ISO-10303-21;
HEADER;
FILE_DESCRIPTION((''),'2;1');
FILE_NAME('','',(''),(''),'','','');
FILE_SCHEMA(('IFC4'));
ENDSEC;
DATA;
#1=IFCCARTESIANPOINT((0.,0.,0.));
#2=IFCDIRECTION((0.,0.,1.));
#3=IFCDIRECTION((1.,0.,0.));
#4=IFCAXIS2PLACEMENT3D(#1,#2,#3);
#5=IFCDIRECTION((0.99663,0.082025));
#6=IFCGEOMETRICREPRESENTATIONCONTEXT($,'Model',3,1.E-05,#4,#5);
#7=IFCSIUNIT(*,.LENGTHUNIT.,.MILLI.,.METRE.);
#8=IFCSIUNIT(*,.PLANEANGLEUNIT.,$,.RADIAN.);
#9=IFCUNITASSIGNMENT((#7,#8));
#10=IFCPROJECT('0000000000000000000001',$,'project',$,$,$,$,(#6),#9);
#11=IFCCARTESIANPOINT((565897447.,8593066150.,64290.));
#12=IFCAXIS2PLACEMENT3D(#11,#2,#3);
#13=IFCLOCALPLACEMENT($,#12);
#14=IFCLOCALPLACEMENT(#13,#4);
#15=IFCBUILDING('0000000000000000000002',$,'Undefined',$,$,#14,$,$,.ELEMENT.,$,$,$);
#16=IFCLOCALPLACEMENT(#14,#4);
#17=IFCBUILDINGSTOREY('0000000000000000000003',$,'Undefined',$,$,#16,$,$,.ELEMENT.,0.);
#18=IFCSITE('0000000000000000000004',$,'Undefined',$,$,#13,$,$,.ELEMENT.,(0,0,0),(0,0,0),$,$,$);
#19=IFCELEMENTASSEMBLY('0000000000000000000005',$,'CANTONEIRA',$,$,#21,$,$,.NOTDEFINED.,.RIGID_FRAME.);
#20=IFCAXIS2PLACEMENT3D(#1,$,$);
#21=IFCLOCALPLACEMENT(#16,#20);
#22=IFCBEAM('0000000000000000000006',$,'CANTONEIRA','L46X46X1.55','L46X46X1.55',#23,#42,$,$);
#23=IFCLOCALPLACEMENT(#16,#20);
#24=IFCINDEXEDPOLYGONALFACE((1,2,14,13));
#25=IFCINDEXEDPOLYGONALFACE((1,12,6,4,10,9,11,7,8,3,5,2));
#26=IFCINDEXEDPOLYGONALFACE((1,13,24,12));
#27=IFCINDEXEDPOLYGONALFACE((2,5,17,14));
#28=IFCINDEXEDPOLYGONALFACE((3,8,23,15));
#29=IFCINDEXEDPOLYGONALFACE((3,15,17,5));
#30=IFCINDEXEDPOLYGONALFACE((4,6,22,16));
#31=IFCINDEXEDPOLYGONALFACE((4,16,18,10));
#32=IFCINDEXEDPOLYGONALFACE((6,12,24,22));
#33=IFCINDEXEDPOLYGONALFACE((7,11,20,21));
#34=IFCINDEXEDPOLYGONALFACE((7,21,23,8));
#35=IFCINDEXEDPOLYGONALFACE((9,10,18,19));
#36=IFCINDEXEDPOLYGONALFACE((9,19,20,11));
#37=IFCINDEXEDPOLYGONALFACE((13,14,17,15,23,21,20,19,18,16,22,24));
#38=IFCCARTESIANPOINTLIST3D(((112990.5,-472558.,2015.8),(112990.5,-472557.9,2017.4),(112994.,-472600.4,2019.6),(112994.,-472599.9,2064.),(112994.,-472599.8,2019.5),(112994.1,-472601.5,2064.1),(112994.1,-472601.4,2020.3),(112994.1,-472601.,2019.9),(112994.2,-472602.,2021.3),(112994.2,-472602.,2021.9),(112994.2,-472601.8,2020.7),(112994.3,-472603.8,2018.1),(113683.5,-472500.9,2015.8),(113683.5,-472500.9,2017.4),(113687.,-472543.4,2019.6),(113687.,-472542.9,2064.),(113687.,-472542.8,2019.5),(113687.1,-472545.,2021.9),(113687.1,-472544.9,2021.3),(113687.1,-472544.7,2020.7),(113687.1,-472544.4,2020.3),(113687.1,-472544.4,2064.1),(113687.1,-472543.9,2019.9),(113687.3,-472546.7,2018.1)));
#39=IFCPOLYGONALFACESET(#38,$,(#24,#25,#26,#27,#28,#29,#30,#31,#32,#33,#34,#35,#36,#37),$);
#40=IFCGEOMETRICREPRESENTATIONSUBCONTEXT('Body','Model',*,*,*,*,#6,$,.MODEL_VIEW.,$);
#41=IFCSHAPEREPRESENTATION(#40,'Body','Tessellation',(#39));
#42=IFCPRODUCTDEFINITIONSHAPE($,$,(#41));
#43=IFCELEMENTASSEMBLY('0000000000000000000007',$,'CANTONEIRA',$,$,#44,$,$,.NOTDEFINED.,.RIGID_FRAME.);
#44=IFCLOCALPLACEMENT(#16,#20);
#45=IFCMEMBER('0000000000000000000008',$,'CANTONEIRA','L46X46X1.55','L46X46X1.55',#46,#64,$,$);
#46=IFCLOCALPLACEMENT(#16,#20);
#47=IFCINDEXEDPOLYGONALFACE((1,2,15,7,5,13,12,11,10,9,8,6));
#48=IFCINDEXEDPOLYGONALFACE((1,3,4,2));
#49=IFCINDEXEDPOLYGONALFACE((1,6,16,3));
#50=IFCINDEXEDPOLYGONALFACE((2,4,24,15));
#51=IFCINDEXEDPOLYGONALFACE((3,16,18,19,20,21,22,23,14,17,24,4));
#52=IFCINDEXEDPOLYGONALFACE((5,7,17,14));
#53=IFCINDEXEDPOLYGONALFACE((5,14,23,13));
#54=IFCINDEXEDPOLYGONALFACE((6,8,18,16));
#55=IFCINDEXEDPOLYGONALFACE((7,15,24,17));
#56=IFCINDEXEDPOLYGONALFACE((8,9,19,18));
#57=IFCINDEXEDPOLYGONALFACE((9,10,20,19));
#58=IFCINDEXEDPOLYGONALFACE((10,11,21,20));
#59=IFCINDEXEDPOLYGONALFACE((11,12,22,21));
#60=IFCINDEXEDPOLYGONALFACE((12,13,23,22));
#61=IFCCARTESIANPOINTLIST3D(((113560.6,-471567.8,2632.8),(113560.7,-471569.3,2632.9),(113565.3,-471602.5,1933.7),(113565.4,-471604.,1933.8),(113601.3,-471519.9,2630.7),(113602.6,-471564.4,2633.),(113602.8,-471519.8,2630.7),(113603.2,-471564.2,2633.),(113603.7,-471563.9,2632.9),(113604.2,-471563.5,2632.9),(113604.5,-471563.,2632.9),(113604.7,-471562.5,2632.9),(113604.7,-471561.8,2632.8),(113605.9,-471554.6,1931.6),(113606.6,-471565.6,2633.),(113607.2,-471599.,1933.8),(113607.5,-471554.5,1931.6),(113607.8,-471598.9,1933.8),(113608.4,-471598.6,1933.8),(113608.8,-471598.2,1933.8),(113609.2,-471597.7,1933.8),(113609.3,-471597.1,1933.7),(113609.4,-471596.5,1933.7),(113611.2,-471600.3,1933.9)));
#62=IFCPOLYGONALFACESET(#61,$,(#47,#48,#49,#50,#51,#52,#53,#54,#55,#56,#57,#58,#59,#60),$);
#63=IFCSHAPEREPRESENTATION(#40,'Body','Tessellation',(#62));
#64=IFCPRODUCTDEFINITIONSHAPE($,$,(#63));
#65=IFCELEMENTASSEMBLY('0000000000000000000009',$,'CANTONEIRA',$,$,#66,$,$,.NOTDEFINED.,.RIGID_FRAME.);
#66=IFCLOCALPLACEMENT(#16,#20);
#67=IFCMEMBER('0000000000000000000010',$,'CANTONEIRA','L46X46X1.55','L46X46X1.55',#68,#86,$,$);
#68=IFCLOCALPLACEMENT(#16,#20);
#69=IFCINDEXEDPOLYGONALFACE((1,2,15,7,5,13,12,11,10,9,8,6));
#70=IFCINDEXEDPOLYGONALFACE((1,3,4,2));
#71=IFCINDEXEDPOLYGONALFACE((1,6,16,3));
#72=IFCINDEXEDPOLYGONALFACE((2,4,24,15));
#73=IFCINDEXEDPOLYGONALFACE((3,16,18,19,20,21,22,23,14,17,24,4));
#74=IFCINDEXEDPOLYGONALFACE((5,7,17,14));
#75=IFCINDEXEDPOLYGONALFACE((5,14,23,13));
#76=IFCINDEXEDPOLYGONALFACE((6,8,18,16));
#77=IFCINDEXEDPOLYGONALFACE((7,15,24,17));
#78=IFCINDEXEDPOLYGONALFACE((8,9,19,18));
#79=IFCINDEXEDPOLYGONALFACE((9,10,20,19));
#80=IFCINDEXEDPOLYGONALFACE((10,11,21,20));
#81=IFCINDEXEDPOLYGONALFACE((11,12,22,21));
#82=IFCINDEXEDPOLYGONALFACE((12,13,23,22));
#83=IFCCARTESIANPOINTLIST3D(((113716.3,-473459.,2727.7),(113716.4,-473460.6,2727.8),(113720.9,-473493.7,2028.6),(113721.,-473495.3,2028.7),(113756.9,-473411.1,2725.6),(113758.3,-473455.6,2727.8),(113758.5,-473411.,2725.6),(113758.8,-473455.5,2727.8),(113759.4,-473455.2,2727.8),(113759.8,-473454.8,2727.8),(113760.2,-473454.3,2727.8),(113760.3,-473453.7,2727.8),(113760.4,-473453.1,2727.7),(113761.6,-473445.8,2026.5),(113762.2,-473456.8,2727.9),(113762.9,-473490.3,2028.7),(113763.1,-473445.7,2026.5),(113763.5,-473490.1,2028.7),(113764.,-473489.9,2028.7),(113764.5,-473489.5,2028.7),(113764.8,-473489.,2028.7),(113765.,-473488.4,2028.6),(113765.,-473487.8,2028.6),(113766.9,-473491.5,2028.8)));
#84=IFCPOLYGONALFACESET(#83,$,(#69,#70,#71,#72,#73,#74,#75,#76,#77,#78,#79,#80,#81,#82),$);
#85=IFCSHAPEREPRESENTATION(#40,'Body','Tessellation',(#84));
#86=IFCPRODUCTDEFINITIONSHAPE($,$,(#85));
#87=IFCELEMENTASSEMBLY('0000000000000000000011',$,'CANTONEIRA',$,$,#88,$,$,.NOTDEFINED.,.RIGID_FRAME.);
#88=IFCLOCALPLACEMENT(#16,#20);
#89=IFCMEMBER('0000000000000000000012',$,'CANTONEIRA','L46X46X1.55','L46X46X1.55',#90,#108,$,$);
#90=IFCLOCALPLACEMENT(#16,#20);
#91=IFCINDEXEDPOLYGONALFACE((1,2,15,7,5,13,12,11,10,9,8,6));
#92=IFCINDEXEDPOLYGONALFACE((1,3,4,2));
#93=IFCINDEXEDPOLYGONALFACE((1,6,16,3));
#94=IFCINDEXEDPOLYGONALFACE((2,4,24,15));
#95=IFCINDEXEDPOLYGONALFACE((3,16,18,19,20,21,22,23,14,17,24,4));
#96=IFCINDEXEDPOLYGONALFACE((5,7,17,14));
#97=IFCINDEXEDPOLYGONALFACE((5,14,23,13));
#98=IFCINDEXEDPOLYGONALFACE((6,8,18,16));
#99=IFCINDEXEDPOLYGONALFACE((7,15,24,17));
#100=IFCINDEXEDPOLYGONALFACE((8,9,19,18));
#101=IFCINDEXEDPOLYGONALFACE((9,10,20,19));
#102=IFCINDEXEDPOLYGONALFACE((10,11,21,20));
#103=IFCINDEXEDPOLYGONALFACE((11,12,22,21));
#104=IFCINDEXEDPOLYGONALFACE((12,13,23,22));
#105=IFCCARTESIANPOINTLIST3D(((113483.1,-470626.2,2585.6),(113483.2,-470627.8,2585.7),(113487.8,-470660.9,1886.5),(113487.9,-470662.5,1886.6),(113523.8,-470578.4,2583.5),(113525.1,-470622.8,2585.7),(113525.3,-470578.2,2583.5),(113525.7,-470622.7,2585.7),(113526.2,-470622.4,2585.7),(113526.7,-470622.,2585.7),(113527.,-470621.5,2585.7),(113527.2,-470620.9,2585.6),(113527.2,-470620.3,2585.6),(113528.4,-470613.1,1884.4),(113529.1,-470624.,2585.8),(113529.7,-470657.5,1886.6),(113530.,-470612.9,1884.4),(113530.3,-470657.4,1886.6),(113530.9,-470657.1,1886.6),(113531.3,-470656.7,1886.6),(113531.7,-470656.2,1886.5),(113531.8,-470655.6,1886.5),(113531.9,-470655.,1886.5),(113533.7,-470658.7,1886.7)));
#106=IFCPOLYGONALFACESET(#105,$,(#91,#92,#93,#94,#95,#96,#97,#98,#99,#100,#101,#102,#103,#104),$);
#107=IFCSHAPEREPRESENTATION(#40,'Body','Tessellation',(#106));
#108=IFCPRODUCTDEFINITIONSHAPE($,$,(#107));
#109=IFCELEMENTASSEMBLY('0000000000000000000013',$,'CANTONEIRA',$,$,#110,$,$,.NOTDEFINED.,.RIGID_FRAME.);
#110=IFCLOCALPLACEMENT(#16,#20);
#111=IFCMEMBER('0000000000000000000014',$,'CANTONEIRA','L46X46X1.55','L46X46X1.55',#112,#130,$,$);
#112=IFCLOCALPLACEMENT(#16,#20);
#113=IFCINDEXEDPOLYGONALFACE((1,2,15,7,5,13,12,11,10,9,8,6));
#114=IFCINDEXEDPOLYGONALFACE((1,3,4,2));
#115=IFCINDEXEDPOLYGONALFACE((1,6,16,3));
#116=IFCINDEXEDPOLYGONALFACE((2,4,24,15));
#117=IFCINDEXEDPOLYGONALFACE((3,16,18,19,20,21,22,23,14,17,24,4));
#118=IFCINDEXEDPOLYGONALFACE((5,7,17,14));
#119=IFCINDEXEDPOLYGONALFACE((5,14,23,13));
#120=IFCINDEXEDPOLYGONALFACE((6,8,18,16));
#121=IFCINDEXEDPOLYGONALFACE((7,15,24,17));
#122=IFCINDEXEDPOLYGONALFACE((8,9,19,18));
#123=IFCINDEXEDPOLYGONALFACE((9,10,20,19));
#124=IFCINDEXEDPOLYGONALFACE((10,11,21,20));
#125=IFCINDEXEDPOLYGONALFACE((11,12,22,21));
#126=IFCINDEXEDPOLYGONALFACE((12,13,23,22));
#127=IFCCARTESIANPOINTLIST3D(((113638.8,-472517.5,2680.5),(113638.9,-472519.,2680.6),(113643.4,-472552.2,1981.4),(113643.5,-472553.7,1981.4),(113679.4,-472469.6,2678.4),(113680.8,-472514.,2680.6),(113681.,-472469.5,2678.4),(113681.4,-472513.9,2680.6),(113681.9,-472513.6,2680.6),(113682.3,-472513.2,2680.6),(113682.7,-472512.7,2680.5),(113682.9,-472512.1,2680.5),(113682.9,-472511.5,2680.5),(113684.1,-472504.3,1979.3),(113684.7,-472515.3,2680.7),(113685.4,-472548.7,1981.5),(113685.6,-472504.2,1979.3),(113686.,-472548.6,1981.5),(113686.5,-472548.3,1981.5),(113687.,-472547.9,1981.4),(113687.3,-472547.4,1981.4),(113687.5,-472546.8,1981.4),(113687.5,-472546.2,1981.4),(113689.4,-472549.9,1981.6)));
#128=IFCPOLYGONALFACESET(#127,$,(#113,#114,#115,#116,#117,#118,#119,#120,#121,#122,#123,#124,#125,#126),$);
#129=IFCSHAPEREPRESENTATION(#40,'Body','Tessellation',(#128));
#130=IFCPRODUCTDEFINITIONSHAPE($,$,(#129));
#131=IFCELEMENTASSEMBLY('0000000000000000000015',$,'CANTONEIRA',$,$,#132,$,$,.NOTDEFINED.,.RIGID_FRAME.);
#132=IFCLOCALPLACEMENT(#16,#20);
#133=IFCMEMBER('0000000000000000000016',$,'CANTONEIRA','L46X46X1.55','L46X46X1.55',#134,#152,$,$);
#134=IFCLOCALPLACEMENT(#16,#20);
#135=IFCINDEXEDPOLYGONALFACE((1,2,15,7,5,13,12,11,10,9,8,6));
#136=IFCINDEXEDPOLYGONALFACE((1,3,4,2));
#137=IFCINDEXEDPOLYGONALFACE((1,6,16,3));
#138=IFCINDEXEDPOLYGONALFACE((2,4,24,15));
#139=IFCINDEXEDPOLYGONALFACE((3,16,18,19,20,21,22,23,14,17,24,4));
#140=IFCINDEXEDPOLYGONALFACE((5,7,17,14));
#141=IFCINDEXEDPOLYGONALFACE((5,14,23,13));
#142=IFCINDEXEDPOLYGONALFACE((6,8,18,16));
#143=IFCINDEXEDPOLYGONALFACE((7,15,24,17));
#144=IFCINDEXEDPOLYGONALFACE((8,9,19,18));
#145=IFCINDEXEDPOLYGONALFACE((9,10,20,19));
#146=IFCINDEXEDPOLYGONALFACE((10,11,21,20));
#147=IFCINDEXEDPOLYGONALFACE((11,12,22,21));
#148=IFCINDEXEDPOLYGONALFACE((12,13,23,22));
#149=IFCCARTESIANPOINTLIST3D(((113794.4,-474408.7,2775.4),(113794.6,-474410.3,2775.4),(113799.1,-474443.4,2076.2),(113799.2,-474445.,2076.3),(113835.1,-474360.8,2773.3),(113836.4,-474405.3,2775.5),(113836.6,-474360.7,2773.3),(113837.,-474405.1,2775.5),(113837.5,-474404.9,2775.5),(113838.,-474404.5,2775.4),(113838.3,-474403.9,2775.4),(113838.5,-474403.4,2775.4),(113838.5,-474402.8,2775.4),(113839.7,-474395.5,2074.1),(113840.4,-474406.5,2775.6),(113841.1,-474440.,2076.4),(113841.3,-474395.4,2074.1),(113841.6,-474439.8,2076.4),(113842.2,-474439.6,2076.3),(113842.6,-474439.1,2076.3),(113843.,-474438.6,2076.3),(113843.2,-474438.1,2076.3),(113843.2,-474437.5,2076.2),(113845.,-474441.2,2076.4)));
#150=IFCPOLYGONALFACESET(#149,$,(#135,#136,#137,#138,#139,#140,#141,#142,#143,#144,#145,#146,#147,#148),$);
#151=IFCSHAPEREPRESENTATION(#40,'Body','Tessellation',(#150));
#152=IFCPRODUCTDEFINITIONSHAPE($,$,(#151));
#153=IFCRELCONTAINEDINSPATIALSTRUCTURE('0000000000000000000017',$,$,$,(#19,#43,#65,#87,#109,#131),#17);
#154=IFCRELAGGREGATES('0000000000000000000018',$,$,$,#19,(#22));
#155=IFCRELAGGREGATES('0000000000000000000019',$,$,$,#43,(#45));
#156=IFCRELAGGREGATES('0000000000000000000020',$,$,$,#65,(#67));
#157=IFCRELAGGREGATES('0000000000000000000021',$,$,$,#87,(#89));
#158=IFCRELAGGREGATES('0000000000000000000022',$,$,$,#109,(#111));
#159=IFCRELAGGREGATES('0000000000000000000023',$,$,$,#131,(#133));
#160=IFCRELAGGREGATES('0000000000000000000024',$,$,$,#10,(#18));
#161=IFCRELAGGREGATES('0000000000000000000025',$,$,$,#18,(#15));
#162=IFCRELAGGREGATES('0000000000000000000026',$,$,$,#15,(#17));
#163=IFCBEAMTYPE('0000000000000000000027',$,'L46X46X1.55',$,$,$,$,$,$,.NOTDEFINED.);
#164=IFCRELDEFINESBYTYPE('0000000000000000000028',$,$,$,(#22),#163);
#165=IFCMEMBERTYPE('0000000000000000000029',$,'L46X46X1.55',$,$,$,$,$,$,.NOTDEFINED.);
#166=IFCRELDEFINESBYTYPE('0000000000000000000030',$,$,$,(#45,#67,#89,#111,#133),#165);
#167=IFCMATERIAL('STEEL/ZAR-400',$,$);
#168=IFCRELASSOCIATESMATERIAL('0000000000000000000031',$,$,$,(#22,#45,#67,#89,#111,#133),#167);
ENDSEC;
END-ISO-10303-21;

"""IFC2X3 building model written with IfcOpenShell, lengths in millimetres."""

from ifc_helpers import new_model, si_unit, direction, frame, frame_2d, origin_with_axes, place, context, subcontext, project, spatial, l_section, extrude, material, type_object, element, aggregate, save


model = new_model("IFC2X3")

# Units and contexts
model_context = context("Model", 3, precision=1e-05, world=origin_with_axes(), true_north=direction((0.99663, 0.082025)))
body_context = subcontext(model_context, "Body", "Model", "MODEL_VIEW")
ifc_project = project(units=[si_unit("LENGTHUNIT", "METRE", prefix="MILLI"), si_unit("PLANEANGLEUNIT", "RADIAN")], contexts=[model_context])

# Site, building, storey
site_placement = place(None, frame((565897447.0, 8593066150.0, 64290.0), z_axis=(0.0, 0.0, 1.0), x_axis=(1.0, 0.0, 0.0)))
site = spatial("IfcSite", under=ifc_project, at=site_placement, Name="Undefined", CompositionType="ELEMENT", RefLatitude=(0, 0, 0), RefLongitude=(0, 0, 0))
building_placement = place(site_placement, origin_with_axes())
building = spatial("IfcBuilding", under=site, at=building_placement, Name="Undefined", CompositionType="ELEMENT")
storey_placement = place(building_placement, origin_with_axes())
storey = spatial("IfcBuildingStorey", under=building, at=storey_placement, Name="Undefined", CompositionType="ELEMENT", Elevation=0.0)

# Element assembly, beam
ifc_material_1 = material(Name="STEEL/ZAR-400")
beam_type_1 = type_object("IfcBeamType", Name="L46X46X1.55", PredefinedType="NOTDEFINED")
assembly_1_placement = place(storey_placement, origin_with_axes())
assembly_1 = element("IfcElementAssembly", 1, at=assembly_1_placement, inside=storey, Name="CANTONEIRA", AssemblyPlace="NOTDEFINED", PredefinedType="RIGID_FRAME")
beam_1_placement = place(assembly_1_placement, frame((112992.3, -472579.7, 2040.0), z_axis=(-0.081923, 0.995387, -0.049938), x_axis=(0.99663, 0.082025, 0.0)))
beam_1 = element("IfcBeam", 2, at=beam_1_placement, type_object=beam_type_1, material=ifc_material_1, Name="CANTONEIRA", Description="L46X46X1.55", ObjectType="L46X46X1.55", context=body_context, shape_type="SweptSolid", body=[
    extrude(l_section(Depth=46.0, Width=46.0, Thickness=1.6, FilletRadius=2.3, at=frame_2d((0.0, 0.0), x_axis=(1.0, 0.0))), frame((695.3, 0.0, 0.0), z_axis=(-1.0, 0.0, 0.0), x_axis=(0.0, -1.0, 0.0)), (0.0, 0.0, 1.0), 695.3),
])
aggregate(assembly_1, [beam_1])

# Element assemblies, members
assembly_2_placement = place(storey_placement, origin_with_axes())
assembly_2 = element("IfcElementAssembly", 3, at=assembly_2_placement, inside=storey, Name="CANTONEIRA", AssemblyPlace="NOTDEFINED", PredefinedType="RIGID_FRAME")
member_type = type_object("IfcMemberType", Name="L46X46X1.55", PredefinedType="NOTDEFINED")
member_1_placement = place(assembly_2_placement, frame((113586.4, -471579.3, 1932.7), z_axis=(-0.081796, 0.995397, -0.049937), x_axis=(-0.00663, 0.049561, 0.998749)))
member_1 = element("IfcMember", 4, at=member_1_placement, type_object=member_type, material=ifc_material_1, Name="CANTONEIRA", Description="L46X46X1.55", ObjectType="L46X46X1.55", context=body_context, shape_type="SweptSolid", body=[
    extrude(l_section(Depth=46.0, Width=46.0, Thickness=1.6, FilletRadius=2.3, at=frame_2d((0.0, 0.0), x_axis=(1.0, 0.0))), frame((700.0, 0.0, 0.0), z_axis=(-1.0, 0.0, 0.0), x_axis=(0.0, -1.0, 0.0)), (0.0, 0.0, 1.0), 700.0),
])
aggregate(assembly_2, [member_1])
assembly_3_placement = place(storey_placement, origin_with_axes())
assembly_3 = element("IfcElementAssembly", 5, at=assembly_3_placement, inside=storey, Name="CANTONEIRA", AssemblyPlace="NOTDEFINED", PredefinedType="RIGID_FRAME")
member_2_placement = place(assembly_3_placement, frame((113742.1, -473470.5, 2027.6), z_axis=(-0.081796, 0.995397, -0.049937), x_axis=(-0.00663, 0.049561, 0.998749)))
member_2 = element("IfcMember", 6, at=member_2_placement, type_object=member_type, material=ifc_material_1, Name="CANTONEIRA", Description="L46X46X1.55", ObjectType="L46X46X1.55", context=body_context, shape_type="SweptSolid", body=[
    extrude(l_section(Depth=46.0, Width=46.0, Thickness=1.6, FilletRadius=2.3, at=frame_2d((0.0, 0.0), x_axis=(1.0, 0.0))), frame((700.0, 0.0, 0.0), z_axis=(-1.0, 0.0, 0.0), x_axis=(0.0, -1.0, 0.0)), (0.0, 0.0, 1.0), 700.0),
])
aggregate(assembly_3, [member_2])
assembly_4_placement = place(storey_placement, origin_with_axes())
assembly_4 = element("IfcElementAssembly", 7, at=assembly_4_placement, inside=storey, Name="CANTONEIRA", AssemblyPlace="NOTDEFINED", PredefinedType="RIGID_FRAME")
member_3_placement = place(assembly_4_placement, frame((113508.9, -470637.7, 1885.5), z_axis=(-0.081796, 0.995397, -0.049937), x_axis=(-0.00663, 0.049561, 0.998749)))
member_3 = element("IfcMember", 8, at=member_3_placement, type_object=member_type, material=ifc_material_1, Name="CANTONEIRA", Description="L46X46X1.55", ObjectType="L46X46X1.55", context=body_context, shape_type="SweptSolid", body=[
    extrude(l_section(Depth=46.0, Width=46.0, Thickness=1.6, FilletRadius=2.3, at=frame_2d((0.0, 0.0), x_axis=(1.0, 0.0))), frame((700.0, 0.0, 0.0), z_axis=(-1.0, 0.0, 0.0), x_axis=(0.0, -1.0, 0.0)), (0.0, 0.0, 1.0), 700.0),
])
aggregate(assembly_4, [member_3])
assembly_5_placement = place(storey_placement, origin_with_axes())
assembly_5 = element("IfcElementAssembly", 9, at=assembly_5_placement, inside=storey, Name="CANTONEIRA", AssemblyPlace="NOTDEFINED", PredefinedType="RIGID_FRAME")
member_4_placement = place(assembly_5_placement, frame((113664.6, -472528.9, 1980.4), z_axis=(-0.081796, 0.995397, -0.049937), x_axis=(-0.00663, 0.049561, 0.998749)))
member_4 = element("IfcMember", 10, at=member_4_placement, type_object=member_type, material=ifc_material_1, Name="CANTONEIRA", Description="L46X46X1.55", ObjectType="L46X46X1.55", context=body_context, shape_type="SweptSolid", body=[
    extrude(l_section(Depth=46.0, Width=46.0, Thickness=1.6, FilletRadius=2.3, at=frame_2d((0.0, 0.0), x_axis=(1.0, 0.0))), frame((700.0, 0.0, 0.0), z_axis=(-1.0, 0.0, 0.0), x_axis=(0.0, -1.0, 0.0)), (0.0, 0.0, 1.0), 700.0),
])
aggregate(assembly_5, [member_4])
assembly_6_placement = place(storey_placement, origin_with_axes())
assembly_6 = element("IfcElementAssembly", 11, at=assembly_6_placement, inside=storey, Name="CANTONEIRA", AssemblyPlace="NOTDEFINED", PredefinedType="RIGID_FRAME")
member_5_placement = place(assembly_6_placement, frame((113820.2, -474420.2, 2075.2), z_axis=(-0.081796, 0.995397, -0.049937), x_axis=(-0.00663, 0.049561, 0.998749)))
member_5 = element("IfcMember", 12, at=member_5_placement, type_object=member_type, material=ifc_material_1, Name="CANTONEIRA", Description="L46X46X1.55", ObjectType="L46X46X1.55", context=body_context, shape_type="SweptSolid", body=[
    extrude(l_section(Depth=46.0, Width=46.0, Thickness=1.6, FilletRadius=2.3, at=frame_2d((0.0, 0.0), x_axis=(1.0, 0.0))), frame((700.0, 0.0, 0.0), z_axis=(-1.0, 0.0, 0.0), x_axis=(0.0, -1.0, 0.0)), (0.0, 0.0, 1.0), 700.0),
])
aggregate(assembly_6, [member_5])

save(model, "model.ifc")
